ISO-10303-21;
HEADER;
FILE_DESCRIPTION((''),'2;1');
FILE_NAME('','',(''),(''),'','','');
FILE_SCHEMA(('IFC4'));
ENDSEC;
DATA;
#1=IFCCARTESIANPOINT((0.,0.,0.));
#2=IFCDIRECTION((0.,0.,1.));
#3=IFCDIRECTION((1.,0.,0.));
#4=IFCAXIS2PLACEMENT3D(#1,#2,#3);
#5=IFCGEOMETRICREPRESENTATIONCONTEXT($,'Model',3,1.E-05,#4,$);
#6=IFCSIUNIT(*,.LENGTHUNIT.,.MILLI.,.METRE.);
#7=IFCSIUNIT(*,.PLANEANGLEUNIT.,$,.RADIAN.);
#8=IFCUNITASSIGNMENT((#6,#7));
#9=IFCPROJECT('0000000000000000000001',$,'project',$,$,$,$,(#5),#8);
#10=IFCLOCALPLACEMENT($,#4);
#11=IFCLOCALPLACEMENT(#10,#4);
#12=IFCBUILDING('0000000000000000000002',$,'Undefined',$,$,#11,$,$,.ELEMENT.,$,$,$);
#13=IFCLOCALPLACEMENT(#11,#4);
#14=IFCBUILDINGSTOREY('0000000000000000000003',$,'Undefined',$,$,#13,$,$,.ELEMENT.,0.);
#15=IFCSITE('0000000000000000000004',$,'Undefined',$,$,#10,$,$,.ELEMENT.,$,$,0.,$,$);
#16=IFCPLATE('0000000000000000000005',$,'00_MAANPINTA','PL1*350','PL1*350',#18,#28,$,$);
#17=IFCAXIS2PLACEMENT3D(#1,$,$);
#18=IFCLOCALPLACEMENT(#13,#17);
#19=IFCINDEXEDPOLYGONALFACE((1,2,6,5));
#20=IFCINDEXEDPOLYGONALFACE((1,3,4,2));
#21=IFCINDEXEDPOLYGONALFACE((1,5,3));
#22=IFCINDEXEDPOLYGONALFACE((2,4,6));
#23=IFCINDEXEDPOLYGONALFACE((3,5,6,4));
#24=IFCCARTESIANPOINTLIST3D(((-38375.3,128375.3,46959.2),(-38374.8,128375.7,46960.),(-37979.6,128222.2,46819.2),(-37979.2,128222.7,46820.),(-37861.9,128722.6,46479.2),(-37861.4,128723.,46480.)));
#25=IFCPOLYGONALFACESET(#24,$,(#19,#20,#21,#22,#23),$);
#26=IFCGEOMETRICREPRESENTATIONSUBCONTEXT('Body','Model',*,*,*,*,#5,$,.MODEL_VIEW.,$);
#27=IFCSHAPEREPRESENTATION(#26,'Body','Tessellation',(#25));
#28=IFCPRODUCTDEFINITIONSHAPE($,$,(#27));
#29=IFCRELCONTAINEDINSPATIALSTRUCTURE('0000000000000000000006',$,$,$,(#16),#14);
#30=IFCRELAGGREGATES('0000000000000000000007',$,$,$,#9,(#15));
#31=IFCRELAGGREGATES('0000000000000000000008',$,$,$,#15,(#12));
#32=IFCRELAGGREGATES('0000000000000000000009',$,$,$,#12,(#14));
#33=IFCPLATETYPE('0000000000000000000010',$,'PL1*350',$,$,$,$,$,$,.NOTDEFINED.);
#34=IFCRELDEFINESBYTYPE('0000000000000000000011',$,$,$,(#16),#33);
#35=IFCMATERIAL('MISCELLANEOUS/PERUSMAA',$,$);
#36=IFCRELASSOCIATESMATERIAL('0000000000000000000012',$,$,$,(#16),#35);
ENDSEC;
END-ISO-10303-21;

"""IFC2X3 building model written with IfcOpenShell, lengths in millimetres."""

from ifc_helpers import new_model, si_unit, frame, origin_with_axes, place, context, subcontext, project, spatial, polyline, outline, extrude, material, type_object, element, save


model = new_model("IFC2X3")

# Units and contexts
model_context = context("Model", 3, precision=1e-05, world=origin_with_axes())
body_context = subcontext(model_context, "Body", "Model", "MODEL_VIEW")
ifc_project = project(units=[si_unit("LENGTHUNIT", "METRE", prefix="MILLI"), si_unit("PLANEANGLEUNIT", "RADIAN")], contexts=[model_context])

# Site, building, storey
site_placement = place(None, origin_with_axes())
site = spatial("IfcSite", under=ifc_project, at=site_placement, Name="Undefined", CompositionType="ELEMENT", RefElevation=0.0)
building_placement = place(site_placement, origin_with_axes())
building = spatial("IfcBuilding", under=site, at=building_placement, Name="Undefined", CompositionType="ELEMENT")
storey_placement = place(building_placement, origin_with_axes())
storey = spatial("IfcBuildingStorey", under=building, at=storey_placement, Name="Undefined", CompositionType="ELEMENT", Elevation=0.0)

# Plate
ifc_material = material(Name="MISCELLANEOUS/PERUSMAA")
plate_type_1 = type_object("IfcPlateType", Name="PL1*350", PredefinedType="NOTDEFINED")
plate_1_placement = place(storey_placement, frame((-37979.4, 128222.5, 46819.6), z_axis=(-0.44435, -0.429627, -0.786113), x_axis=(-0.885665, 0.342638, 0.313363)))
element("IfcPlate", 1, at=plate_1_placement, inside=storey, type_object=plate_type_1, material=ifc_material, Name="00_MAANPINTA", Description="PL1*350", ObjectType="PL1*350", context=body_context, shape_type="SweptSolid", body=[
    extrude(outline(polyline([(0.0, 0.0), (446.8, 0.0), (-39.4, 615.0), (0.0, 0.0)])), frame((0.0, 0.0, -0.5), z_axis=(0.0, 0.0, 1.0), x_axis=(1.0, 0.0, 0.0)), (0.0, 0.0, 1.0), 1.0),
])

save(model, "model.ifc")
